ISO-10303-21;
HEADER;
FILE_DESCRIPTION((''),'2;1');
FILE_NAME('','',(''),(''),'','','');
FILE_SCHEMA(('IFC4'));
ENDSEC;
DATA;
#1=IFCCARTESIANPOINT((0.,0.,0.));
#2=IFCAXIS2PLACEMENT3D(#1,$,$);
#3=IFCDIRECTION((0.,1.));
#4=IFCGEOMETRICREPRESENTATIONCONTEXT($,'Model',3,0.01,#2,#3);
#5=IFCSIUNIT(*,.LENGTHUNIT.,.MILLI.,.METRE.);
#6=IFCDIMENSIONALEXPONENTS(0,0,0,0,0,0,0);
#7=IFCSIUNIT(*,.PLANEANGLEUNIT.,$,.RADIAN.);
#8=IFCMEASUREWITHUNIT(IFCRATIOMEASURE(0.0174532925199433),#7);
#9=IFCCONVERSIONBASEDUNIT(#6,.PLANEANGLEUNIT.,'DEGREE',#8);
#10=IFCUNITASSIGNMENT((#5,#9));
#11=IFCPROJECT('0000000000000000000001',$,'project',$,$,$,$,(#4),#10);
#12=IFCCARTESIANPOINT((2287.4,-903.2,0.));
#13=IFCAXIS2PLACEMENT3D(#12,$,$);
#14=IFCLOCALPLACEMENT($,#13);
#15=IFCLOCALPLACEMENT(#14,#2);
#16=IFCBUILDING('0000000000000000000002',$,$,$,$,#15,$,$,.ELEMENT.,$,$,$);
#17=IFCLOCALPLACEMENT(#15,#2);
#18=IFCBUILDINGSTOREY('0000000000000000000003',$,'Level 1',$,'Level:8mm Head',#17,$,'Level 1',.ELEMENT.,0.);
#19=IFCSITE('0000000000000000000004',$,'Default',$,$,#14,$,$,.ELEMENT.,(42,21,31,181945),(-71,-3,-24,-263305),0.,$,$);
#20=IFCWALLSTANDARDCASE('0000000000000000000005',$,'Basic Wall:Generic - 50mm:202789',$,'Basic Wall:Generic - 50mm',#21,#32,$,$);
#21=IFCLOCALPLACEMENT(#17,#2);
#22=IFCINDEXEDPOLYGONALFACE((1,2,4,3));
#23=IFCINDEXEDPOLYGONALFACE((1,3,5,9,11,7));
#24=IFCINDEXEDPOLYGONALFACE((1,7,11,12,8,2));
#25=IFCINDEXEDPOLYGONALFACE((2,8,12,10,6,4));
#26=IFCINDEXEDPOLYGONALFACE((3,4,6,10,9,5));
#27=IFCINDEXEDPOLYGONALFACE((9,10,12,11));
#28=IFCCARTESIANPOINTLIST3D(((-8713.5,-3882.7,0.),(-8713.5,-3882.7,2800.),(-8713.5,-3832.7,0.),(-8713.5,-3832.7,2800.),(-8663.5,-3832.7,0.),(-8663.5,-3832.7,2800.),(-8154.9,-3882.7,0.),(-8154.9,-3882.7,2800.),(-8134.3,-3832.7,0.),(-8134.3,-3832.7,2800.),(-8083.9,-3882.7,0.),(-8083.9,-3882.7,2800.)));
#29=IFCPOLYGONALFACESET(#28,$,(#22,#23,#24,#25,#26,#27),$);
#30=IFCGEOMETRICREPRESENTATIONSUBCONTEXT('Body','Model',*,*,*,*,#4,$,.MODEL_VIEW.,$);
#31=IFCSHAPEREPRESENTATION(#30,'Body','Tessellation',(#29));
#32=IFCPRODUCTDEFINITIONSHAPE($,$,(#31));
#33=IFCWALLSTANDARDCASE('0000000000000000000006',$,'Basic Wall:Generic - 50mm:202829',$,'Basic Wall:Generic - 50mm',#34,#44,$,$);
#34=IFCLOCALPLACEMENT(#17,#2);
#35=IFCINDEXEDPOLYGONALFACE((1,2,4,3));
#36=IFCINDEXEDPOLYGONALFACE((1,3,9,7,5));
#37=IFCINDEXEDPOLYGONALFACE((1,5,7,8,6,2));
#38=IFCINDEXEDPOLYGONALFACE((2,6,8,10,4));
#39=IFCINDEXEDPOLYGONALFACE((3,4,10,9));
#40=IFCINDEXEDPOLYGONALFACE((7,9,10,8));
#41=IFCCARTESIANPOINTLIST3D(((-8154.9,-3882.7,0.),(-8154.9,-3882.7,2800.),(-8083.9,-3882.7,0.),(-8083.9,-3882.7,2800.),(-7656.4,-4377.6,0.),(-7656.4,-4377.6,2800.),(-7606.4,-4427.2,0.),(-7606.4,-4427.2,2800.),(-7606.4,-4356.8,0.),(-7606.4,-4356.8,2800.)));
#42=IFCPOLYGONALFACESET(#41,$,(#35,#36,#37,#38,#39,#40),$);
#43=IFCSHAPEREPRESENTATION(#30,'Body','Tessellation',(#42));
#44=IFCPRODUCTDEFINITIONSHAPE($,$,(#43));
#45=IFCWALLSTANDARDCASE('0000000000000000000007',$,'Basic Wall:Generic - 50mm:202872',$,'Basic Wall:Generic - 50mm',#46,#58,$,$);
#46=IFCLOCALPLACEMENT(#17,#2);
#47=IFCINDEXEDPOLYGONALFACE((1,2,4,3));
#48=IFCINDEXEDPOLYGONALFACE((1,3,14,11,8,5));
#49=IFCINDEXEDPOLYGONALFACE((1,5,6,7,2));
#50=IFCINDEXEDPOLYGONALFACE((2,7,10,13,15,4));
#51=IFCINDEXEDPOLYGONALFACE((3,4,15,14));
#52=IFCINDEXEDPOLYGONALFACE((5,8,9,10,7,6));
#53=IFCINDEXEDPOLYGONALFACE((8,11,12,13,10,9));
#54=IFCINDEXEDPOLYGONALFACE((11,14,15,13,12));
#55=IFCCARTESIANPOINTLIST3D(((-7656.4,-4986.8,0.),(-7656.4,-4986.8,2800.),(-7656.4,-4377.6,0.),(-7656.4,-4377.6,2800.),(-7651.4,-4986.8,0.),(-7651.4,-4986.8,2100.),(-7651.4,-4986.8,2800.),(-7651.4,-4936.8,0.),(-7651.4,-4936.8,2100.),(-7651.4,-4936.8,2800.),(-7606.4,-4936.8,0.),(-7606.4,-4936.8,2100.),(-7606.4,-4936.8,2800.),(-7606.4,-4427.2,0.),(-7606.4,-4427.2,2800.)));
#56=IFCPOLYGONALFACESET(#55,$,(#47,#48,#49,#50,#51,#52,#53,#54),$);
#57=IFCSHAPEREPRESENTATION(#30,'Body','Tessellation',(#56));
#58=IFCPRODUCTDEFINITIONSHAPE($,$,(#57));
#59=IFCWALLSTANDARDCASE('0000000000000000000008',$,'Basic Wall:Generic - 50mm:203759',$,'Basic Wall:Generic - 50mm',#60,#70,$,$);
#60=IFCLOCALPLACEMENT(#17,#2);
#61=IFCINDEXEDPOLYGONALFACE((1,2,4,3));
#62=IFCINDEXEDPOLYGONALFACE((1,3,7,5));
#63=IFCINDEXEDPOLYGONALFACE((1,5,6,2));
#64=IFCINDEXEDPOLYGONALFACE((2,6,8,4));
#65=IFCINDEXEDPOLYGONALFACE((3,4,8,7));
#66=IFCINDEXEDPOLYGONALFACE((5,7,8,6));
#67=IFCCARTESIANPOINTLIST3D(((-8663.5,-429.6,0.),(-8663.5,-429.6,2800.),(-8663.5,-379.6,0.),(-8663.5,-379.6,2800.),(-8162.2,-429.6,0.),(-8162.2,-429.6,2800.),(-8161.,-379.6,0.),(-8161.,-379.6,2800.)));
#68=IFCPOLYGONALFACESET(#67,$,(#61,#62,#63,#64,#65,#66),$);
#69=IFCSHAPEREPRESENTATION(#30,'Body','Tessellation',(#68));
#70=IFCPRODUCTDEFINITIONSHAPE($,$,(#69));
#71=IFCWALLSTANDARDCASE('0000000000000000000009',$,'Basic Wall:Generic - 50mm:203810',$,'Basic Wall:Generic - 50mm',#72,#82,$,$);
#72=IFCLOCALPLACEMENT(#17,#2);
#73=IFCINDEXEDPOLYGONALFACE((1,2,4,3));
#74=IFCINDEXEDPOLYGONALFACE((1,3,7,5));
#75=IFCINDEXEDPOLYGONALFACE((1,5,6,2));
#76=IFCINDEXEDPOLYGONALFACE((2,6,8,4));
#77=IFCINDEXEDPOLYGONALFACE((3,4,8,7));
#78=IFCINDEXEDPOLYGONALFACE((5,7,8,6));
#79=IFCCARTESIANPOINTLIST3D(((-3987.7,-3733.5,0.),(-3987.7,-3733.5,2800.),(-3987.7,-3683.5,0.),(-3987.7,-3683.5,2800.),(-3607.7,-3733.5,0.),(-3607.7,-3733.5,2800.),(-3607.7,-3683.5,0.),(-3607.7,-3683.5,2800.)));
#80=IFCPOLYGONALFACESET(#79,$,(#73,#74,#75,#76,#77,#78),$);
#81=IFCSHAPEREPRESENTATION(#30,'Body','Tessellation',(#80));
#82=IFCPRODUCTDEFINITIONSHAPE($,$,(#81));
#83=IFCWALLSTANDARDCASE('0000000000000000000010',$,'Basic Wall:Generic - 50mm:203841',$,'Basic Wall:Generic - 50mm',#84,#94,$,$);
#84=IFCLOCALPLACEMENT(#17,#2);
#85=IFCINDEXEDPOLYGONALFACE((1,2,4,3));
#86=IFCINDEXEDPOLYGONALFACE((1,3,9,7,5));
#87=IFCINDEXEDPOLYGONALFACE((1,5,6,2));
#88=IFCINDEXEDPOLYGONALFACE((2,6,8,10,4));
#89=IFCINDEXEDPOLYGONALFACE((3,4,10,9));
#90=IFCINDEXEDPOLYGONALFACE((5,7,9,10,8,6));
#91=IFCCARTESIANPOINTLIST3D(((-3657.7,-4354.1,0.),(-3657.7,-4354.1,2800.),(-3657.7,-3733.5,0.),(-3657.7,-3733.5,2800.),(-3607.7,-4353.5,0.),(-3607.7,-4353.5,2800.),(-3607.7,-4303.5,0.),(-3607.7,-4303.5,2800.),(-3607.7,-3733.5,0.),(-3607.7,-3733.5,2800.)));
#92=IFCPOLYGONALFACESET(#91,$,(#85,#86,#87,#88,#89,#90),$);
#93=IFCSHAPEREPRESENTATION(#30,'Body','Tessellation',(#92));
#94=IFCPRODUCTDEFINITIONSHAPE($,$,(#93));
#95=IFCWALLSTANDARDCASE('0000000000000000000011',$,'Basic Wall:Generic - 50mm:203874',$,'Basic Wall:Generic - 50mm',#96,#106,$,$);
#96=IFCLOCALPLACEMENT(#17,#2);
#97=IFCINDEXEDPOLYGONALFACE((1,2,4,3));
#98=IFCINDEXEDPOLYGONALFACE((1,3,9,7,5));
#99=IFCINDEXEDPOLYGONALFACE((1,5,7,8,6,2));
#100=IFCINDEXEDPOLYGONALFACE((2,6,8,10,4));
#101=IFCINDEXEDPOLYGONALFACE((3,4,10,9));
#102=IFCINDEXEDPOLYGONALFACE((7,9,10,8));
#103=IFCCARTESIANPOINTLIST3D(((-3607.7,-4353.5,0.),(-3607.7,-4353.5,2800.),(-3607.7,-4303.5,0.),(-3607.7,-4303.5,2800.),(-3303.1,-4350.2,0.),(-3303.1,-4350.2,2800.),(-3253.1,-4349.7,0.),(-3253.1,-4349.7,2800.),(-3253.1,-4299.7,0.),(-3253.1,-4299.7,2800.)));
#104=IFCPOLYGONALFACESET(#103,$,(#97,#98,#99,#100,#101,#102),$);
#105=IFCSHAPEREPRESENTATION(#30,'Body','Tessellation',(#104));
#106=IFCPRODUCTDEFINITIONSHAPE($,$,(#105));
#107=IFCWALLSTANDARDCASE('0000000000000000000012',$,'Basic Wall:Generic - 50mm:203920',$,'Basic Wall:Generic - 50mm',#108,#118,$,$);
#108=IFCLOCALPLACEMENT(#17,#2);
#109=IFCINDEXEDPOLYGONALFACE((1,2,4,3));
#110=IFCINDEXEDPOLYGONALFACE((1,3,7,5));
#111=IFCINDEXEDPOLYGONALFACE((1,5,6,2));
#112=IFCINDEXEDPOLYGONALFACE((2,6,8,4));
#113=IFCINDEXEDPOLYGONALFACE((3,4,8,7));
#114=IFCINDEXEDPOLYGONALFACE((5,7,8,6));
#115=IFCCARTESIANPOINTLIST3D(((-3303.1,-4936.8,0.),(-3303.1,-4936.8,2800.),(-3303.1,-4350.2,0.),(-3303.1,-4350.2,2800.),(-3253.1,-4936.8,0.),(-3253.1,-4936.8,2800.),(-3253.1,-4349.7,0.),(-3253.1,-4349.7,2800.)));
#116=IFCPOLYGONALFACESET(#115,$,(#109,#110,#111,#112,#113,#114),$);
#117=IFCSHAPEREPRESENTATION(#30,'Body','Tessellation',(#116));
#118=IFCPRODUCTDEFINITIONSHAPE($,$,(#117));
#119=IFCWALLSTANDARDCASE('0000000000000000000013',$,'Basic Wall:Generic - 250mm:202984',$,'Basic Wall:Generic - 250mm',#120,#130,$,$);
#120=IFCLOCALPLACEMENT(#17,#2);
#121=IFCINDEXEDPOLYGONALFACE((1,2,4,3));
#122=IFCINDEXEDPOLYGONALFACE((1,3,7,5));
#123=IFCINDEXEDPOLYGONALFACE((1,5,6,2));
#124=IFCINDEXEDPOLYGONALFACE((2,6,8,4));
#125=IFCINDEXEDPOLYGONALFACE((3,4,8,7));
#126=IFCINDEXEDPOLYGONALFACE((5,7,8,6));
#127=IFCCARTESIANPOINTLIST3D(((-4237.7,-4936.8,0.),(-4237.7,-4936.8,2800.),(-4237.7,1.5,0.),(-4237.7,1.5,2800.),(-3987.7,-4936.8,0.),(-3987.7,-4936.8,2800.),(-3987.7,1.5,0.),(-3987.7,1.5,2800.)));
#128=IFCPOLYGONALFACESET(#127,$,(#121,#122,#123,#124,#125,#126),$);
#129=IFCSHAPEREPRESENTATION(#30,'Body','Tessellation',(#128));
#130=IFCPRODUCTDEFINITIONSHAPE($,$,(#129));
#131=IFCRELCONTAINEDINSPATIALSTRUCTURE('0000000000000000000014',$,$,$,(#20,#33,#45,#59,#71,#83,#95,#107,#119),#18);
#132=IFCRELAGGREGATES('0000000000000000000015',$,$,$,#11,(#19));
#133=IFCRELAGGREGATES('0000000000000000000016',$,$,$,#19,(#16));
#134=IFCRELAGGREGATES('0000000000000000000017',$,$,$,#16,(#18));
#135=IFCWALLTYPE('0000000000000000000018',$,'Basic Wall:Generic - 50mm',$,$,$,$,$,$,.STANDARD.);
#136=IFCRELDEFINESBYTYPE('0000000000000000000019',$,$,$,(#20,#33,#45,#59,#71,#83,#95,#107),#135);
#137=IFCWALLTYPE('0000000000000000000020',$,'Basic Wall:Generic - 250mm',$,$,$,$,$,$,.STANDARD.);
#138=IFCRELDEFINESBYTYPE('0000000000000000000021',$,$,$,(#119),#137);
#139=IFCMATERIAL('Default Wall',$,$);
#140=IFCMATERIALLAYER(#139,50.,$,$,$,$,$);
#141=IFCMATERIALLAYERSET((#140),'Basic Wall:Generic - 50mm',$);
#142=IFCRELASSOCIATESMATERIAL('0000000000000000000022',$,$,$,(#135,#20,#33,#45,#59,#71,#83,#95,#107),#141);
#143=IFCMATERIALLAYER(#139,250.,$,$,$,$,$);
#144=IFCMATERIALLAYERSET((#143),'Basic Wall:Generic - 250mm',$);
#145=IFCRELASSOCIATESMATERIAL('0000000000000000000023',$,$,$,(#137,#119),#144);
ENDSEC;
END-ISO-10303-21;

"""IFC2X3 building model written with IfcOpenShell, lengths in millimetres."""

from ifc_helpers import new_model, entity, si_unit, converted_unit, direction, frame, frame_2d, origin, place, context, subcontext, project, spatial, polyline, rectangle, outline, extrude, material, layer, layer_set, layer_usage, type_object, element, save


model = new_model("IFC2X3")

# Units and contexts
model_context = context("Model", 3, precision=0.01, world=origin(), true_north=direction((0.0, 1.0)))
body_context = subcontext(model_context, "Body", "Model", "MODEL_VIEW")
ifc_project = project(units=[si_unit("LENGTHUNIT", "METRE", prefix="MILLI"), converted_unit("PLANEANGLEUNIT", "DEGREE", entity("IfcRatioMeasure", 0.0174532925199433), si_unit("PLANEANGLEUNIT", "RADIAN"), dimensions=[0, 0, 0, 0, 0, 0, 0])], contexts=[model_context])

# Site, building, storey
site_placement = place(None, frame((2287.4, -903.2, 0.0)))
site = spatial("IfcSite", under=ifc_project, at=site_placement, Name="Default", CompositionType="ELEMENT", RefLatitude=(42, 21, 31, 181945), RefLongitude=(-71, -3, -24, -263305), RefElevation=0.0)
building_placement = place(site_placement, origin())
building = spatial("IfcBuilding", under=site, at=building_placement, CompositionType="ELEMENT")
storey_placement = place(building_placement, origin())
storey = spatial("IfcBuildingStorey", under=building, at=storey_placement, Name="Level 1", ObjectType="Level:8mm Head", LongName="Level 1", CompositionType="ELEMENT", Elevation=0.0)

# Walls
ifc_material_1 = material(Name="Default Wall")
ifc_layer_1 = layer(ifc_material_1, 50.0)
ifc_layer_set_1 = layer_set([ifc_layer_1], Name="Basic Wall:Generic - 50mm")
ifc_layer_usage_1 = layer_usage(ifc_layer_set_1, "AXIS2", "NEGATIVE", 25.0)
wall_type_1 = type_object("IfcWallType", Name="Basic Wall:Generic - 50mm", PredefinedType="STANDARD", material=ifc_layer_set_1)
wall_1_placement = place(storey_placement, frame((-8713.5, -3857.7, 0.0)))
element("IfcWallStandardCase", 1, at=wall_1_placement, inside=storey, type_object=wall_type_1, material=ifc_layer_usage_1, Name="Basic Wall:Generic - 50mm:202789", ObjectType="Basic Wall:Generic - 50mm", context=body_context, shape_type="SweptSolid", body=[
    extrude(outline(polyline([(629.6, -25.0), (579.2, 25.0), (50.0, 25.0), (0.0, 25.0), (0.0, -25.0), (558.6, -25.0), (629.6, -25.0)])), origin(), (0.0, 0.0, 1.0), 2800.0),
])
ifc_layer_usage_2 = layer_usage(ifc_layer_set_1, "AXIS2", "NEGATIVE", 25.0)
wall_2_placement = place(storey_placement, frame((-8137.3, -3865.0, 0.0), z_axis=(0.0, 0.0, 1.0), x_axis=(0.709681, -0.704524, 0.0)))
element("IfcWallStandardCase", 2, at=wall_2_placement, inside=storey, type_object=wall_type_1, material=ifc_layer_usage_2, Name="Basic Wall:Generic - 50mm:202829", ObjectType="Basic Wall:Generic - 50mm", context=body_context, shape_type="SweptSolid", body=[
    extrude(outline(polyline([(772.9, -25.0), (723.2, 25.0), (50.4, 25.0), (0.0, -25.0), (702.4, -25.0), (772.9, -25.0)])), origin(), (0.0, 0.0, 1.0), 2800.0),
])

# Wall, opening
ifc_layer_usage_3 = layer_usage(ifc_layer_set_1, "AXIS2", "NEGATIVE", 25.0)
wall_3_placement = place(storey_placement, frame((-7631.4, -4377.6, 0.0), z_axis=(0.0, 0.0, 1.0), x_axis=(0.0, -1.0, 0.0)))
wall_3 = element("IfcWallStandardCase", 3, at=wall_3_placement, inside=storey, type_object=wall_type_1, material=ifc_layer_usage_3, Name="Basic Wall:Generic - 50mm:202872", ObjectType="Basic Wall:Generic - 50mm", context=body_context, shape_type="SweptSolid", body=[
    extrude(outline(polyline([(609.2, -25.0), (609.2, -20.0), (559.2, -20.0), (559.2, 25.0), (49.6, 25.0), (0.0, -25.0), (609.2, -25.0)])), origin(), (0.0, 0.0, 1.0), 2800.0),
])
opening_1_placement = place(wall_3_placement, origin())
element("IfcOpeningElement", 4, at=opening_1_placement, cuts=wall_3, ObjectType="Opening", context=body_context, shape_type="SweptSolid", body=[
    extrude(rectangle(XDim=2100.0, YDim=50.0, at=frame_2d((0.0, 0.0), x_axis=(0.0, 1.0))), frame((584.2, -20.0, 1050.0), z_axis=(0.0, 1.0, 0.0), x_axis=(-1.0, 0.0, 0.0)), (0.0, 0.0, 1.0), 3400.0),
])

# Walls
ifc_layer_usage_4 = layer_usage(ifc_layer_set_1, "AXIS2", "NEGATIVE", 25.0)
wall_4_placement = place(storey_placement, frame((-8161.0, -404.6, 0.0), z_axis=(0.0, 0.0, 1.0), x_axis=(-1.0, 0.0, 0.0)))
element("IfcWallStandardCase", 5, at=wall_4_placement, inside=storey, type_object=wall_type_1, material=ifc_layer_usage_4, Name="Basic Wall:Generic - 50mm:203759", ObjectType="Basic Wall:Generic - 50mm", context=body_context, shape_type="SweptSolid", body=[
    extrude(outline(polyline([(502.5, -25.0), (502.5, 25.0), (1.2, 25.0), (0.0, -25.0), (502.5, -25.0)])), origin(), (0.0, 0.0, 1.0), 2800.0),
])
ifc_layer_usage_5 = layer_usage(ifc_layer_set_1, "AXIS2", "NEGATIVE", 25.0)
wall_5_placement = place(storey_placement, frame((-3987.7, -3708.5, 0.0)))
element("IfcWallStandardCase", 6, at=wall_5_placement, inside=storey, type_object=wall_type_1, material=ifc_layer_usage_5, Name="Basic Wall:Generic - 50mm:203810", ObjectType="Basic Wall:Generic - 50mm", context=body_context, shape_type="SweptSolid", body=[
    extrude(rectangle(XDim=380.0, YDim=50.0, at=frame_2d((190.0, 0.0), x_axis=(-1.0, 0.0))), origin(), (0.0, 0.0, 1.0), 2800.0),
])
ifc_layer_usage_6 = layer_usage(ifc_layer_set_1, "AXIS2", "NEGATIVE", 25.0)
wall_6_placement = place(storey_placement, frame((-3632.7, -3733.5, 0.0), z_axis=(0.0, 0.0, 1.0), x_axis=(0.0, -1.0, 0.0)))
element("IfcWallStandardCase", 7, at=wall_6_placement, inside=storey, type_object=wall_type_1, material=ifc_layer_usage_6, Name="Basic Wall:Generic - 50mm:203841", ObjectType="Basic Wall:Generic - 50mm", context=body_context, shape_type="SweptSolid", body=[
    extrude(outline(polyline([(620.5, -25.0), (620.0, 25.0), (570.0, 25.0), (0.0, 25.0), (0.0, -25.0), (620.5, -25.0)])), origin(), (0.0, 0.0, 1.0), 2800.0),
])
ifc_layer_usage_7 = layer_usage(ifc_layer_set_1, "AXIS2", "NEGATIVE", 25.0)
wall_7_placement = place(storey_placement, frame((-3608.0, -4328.5, 0.0), z_axis=(0.0, 0.0, 1.0), x_axis=(0.999942, 0.010745, 0.0)))
element("IfcWallStandardCase", 8, at=wall_7_placement, inside=storey, type_object=wall_type_1, material=ifc_layer_usage_7, Name="Basic Wall:Generic - 50mm:203874", ObjectType="Basic Wall:Generic - 50mm", context=body_context, shape_type="SweptSolid", body=[
    extrude(outline(polyline([(354.6, -25.0), (355.1, 25.0), (0.5, 25.0), (0.0, -25.0), (304.6, -25.0), (354.6, -25.0)])), origin(), (0.0, 0.0, 1.0), 2800.0),
])
ifc_layer_usage_8 = layer_usage(ifc_layer_set_1, "AXIS2", "NEGATIVE", 25.0)
wall_8_placement = place(storey_placement, frame((-3278.1, -4349.7, 0.0), z_axis=(0.0, 0.0, 1.0), x_axis=(0.0, -1.0, 0.0)))
element("IfcWallStandardCase", 9, at=wall_8_placement, inside=storey, type_object=wall_type_1, material=ifc_layer_usage_8, Name="Basic Wall:Generic - 50mm:203920", ObjectType="Basic Wall:Generic - 50mm", context=body_context, shape_type="SweptSolid", body=[
    extrude(outline(polyline([(587.1, -25.0), (587.1, 25.0), (0.0, 25.0), (0.5, -25.0), (587.1, -25.0)])), origin(), (0.0, 0.0, 1.0), 2800.0),
])

# Wall
ifc_layer_2 = layer(ifc_material_1, 250.0)
ifc_layer_set_2 = layer_set([ifc_layer_2], Name="Basic Wall:Generic - 250mm")
ifc_layer_usage_9 = layer_usage(ifc_layer_set_2, "AXIS2", "POSITIVE", -125.0)
wall_type_2 = type_object("IfcWallType", Name="Basic Wall:Generic - 250mm", PredefinedType="STANDARD", material=ifc_layer_set_2)
wall_9_placement = place(storey_placement, frame((-4112.7, 1.5, 0.0), z_axis=(0.0, 0.0, 1.0), x_axis=(0.0, -1.0, 0.0)))
element("IfcWallStandardCase", 10, at=wall_9_placement, inside=storey, type_object=wall_type_2, material=ifc_layer_usage_9, Name="Basic Wall:Generic - 250mm:202984", ObjectType="Basic Wall:Generic - 250mm", context=body_context, shape_type="SweptSolid", body=[
    extrude(rectangle(XDim=4938.3, YDim=250.0, at=frame_2d((2469.1, 0.0), x_axis=(-1.0, 0.0))), origin(), (0.0, 0.0, 1.0), 2800.0),
])

save(model, "model.ifc")
